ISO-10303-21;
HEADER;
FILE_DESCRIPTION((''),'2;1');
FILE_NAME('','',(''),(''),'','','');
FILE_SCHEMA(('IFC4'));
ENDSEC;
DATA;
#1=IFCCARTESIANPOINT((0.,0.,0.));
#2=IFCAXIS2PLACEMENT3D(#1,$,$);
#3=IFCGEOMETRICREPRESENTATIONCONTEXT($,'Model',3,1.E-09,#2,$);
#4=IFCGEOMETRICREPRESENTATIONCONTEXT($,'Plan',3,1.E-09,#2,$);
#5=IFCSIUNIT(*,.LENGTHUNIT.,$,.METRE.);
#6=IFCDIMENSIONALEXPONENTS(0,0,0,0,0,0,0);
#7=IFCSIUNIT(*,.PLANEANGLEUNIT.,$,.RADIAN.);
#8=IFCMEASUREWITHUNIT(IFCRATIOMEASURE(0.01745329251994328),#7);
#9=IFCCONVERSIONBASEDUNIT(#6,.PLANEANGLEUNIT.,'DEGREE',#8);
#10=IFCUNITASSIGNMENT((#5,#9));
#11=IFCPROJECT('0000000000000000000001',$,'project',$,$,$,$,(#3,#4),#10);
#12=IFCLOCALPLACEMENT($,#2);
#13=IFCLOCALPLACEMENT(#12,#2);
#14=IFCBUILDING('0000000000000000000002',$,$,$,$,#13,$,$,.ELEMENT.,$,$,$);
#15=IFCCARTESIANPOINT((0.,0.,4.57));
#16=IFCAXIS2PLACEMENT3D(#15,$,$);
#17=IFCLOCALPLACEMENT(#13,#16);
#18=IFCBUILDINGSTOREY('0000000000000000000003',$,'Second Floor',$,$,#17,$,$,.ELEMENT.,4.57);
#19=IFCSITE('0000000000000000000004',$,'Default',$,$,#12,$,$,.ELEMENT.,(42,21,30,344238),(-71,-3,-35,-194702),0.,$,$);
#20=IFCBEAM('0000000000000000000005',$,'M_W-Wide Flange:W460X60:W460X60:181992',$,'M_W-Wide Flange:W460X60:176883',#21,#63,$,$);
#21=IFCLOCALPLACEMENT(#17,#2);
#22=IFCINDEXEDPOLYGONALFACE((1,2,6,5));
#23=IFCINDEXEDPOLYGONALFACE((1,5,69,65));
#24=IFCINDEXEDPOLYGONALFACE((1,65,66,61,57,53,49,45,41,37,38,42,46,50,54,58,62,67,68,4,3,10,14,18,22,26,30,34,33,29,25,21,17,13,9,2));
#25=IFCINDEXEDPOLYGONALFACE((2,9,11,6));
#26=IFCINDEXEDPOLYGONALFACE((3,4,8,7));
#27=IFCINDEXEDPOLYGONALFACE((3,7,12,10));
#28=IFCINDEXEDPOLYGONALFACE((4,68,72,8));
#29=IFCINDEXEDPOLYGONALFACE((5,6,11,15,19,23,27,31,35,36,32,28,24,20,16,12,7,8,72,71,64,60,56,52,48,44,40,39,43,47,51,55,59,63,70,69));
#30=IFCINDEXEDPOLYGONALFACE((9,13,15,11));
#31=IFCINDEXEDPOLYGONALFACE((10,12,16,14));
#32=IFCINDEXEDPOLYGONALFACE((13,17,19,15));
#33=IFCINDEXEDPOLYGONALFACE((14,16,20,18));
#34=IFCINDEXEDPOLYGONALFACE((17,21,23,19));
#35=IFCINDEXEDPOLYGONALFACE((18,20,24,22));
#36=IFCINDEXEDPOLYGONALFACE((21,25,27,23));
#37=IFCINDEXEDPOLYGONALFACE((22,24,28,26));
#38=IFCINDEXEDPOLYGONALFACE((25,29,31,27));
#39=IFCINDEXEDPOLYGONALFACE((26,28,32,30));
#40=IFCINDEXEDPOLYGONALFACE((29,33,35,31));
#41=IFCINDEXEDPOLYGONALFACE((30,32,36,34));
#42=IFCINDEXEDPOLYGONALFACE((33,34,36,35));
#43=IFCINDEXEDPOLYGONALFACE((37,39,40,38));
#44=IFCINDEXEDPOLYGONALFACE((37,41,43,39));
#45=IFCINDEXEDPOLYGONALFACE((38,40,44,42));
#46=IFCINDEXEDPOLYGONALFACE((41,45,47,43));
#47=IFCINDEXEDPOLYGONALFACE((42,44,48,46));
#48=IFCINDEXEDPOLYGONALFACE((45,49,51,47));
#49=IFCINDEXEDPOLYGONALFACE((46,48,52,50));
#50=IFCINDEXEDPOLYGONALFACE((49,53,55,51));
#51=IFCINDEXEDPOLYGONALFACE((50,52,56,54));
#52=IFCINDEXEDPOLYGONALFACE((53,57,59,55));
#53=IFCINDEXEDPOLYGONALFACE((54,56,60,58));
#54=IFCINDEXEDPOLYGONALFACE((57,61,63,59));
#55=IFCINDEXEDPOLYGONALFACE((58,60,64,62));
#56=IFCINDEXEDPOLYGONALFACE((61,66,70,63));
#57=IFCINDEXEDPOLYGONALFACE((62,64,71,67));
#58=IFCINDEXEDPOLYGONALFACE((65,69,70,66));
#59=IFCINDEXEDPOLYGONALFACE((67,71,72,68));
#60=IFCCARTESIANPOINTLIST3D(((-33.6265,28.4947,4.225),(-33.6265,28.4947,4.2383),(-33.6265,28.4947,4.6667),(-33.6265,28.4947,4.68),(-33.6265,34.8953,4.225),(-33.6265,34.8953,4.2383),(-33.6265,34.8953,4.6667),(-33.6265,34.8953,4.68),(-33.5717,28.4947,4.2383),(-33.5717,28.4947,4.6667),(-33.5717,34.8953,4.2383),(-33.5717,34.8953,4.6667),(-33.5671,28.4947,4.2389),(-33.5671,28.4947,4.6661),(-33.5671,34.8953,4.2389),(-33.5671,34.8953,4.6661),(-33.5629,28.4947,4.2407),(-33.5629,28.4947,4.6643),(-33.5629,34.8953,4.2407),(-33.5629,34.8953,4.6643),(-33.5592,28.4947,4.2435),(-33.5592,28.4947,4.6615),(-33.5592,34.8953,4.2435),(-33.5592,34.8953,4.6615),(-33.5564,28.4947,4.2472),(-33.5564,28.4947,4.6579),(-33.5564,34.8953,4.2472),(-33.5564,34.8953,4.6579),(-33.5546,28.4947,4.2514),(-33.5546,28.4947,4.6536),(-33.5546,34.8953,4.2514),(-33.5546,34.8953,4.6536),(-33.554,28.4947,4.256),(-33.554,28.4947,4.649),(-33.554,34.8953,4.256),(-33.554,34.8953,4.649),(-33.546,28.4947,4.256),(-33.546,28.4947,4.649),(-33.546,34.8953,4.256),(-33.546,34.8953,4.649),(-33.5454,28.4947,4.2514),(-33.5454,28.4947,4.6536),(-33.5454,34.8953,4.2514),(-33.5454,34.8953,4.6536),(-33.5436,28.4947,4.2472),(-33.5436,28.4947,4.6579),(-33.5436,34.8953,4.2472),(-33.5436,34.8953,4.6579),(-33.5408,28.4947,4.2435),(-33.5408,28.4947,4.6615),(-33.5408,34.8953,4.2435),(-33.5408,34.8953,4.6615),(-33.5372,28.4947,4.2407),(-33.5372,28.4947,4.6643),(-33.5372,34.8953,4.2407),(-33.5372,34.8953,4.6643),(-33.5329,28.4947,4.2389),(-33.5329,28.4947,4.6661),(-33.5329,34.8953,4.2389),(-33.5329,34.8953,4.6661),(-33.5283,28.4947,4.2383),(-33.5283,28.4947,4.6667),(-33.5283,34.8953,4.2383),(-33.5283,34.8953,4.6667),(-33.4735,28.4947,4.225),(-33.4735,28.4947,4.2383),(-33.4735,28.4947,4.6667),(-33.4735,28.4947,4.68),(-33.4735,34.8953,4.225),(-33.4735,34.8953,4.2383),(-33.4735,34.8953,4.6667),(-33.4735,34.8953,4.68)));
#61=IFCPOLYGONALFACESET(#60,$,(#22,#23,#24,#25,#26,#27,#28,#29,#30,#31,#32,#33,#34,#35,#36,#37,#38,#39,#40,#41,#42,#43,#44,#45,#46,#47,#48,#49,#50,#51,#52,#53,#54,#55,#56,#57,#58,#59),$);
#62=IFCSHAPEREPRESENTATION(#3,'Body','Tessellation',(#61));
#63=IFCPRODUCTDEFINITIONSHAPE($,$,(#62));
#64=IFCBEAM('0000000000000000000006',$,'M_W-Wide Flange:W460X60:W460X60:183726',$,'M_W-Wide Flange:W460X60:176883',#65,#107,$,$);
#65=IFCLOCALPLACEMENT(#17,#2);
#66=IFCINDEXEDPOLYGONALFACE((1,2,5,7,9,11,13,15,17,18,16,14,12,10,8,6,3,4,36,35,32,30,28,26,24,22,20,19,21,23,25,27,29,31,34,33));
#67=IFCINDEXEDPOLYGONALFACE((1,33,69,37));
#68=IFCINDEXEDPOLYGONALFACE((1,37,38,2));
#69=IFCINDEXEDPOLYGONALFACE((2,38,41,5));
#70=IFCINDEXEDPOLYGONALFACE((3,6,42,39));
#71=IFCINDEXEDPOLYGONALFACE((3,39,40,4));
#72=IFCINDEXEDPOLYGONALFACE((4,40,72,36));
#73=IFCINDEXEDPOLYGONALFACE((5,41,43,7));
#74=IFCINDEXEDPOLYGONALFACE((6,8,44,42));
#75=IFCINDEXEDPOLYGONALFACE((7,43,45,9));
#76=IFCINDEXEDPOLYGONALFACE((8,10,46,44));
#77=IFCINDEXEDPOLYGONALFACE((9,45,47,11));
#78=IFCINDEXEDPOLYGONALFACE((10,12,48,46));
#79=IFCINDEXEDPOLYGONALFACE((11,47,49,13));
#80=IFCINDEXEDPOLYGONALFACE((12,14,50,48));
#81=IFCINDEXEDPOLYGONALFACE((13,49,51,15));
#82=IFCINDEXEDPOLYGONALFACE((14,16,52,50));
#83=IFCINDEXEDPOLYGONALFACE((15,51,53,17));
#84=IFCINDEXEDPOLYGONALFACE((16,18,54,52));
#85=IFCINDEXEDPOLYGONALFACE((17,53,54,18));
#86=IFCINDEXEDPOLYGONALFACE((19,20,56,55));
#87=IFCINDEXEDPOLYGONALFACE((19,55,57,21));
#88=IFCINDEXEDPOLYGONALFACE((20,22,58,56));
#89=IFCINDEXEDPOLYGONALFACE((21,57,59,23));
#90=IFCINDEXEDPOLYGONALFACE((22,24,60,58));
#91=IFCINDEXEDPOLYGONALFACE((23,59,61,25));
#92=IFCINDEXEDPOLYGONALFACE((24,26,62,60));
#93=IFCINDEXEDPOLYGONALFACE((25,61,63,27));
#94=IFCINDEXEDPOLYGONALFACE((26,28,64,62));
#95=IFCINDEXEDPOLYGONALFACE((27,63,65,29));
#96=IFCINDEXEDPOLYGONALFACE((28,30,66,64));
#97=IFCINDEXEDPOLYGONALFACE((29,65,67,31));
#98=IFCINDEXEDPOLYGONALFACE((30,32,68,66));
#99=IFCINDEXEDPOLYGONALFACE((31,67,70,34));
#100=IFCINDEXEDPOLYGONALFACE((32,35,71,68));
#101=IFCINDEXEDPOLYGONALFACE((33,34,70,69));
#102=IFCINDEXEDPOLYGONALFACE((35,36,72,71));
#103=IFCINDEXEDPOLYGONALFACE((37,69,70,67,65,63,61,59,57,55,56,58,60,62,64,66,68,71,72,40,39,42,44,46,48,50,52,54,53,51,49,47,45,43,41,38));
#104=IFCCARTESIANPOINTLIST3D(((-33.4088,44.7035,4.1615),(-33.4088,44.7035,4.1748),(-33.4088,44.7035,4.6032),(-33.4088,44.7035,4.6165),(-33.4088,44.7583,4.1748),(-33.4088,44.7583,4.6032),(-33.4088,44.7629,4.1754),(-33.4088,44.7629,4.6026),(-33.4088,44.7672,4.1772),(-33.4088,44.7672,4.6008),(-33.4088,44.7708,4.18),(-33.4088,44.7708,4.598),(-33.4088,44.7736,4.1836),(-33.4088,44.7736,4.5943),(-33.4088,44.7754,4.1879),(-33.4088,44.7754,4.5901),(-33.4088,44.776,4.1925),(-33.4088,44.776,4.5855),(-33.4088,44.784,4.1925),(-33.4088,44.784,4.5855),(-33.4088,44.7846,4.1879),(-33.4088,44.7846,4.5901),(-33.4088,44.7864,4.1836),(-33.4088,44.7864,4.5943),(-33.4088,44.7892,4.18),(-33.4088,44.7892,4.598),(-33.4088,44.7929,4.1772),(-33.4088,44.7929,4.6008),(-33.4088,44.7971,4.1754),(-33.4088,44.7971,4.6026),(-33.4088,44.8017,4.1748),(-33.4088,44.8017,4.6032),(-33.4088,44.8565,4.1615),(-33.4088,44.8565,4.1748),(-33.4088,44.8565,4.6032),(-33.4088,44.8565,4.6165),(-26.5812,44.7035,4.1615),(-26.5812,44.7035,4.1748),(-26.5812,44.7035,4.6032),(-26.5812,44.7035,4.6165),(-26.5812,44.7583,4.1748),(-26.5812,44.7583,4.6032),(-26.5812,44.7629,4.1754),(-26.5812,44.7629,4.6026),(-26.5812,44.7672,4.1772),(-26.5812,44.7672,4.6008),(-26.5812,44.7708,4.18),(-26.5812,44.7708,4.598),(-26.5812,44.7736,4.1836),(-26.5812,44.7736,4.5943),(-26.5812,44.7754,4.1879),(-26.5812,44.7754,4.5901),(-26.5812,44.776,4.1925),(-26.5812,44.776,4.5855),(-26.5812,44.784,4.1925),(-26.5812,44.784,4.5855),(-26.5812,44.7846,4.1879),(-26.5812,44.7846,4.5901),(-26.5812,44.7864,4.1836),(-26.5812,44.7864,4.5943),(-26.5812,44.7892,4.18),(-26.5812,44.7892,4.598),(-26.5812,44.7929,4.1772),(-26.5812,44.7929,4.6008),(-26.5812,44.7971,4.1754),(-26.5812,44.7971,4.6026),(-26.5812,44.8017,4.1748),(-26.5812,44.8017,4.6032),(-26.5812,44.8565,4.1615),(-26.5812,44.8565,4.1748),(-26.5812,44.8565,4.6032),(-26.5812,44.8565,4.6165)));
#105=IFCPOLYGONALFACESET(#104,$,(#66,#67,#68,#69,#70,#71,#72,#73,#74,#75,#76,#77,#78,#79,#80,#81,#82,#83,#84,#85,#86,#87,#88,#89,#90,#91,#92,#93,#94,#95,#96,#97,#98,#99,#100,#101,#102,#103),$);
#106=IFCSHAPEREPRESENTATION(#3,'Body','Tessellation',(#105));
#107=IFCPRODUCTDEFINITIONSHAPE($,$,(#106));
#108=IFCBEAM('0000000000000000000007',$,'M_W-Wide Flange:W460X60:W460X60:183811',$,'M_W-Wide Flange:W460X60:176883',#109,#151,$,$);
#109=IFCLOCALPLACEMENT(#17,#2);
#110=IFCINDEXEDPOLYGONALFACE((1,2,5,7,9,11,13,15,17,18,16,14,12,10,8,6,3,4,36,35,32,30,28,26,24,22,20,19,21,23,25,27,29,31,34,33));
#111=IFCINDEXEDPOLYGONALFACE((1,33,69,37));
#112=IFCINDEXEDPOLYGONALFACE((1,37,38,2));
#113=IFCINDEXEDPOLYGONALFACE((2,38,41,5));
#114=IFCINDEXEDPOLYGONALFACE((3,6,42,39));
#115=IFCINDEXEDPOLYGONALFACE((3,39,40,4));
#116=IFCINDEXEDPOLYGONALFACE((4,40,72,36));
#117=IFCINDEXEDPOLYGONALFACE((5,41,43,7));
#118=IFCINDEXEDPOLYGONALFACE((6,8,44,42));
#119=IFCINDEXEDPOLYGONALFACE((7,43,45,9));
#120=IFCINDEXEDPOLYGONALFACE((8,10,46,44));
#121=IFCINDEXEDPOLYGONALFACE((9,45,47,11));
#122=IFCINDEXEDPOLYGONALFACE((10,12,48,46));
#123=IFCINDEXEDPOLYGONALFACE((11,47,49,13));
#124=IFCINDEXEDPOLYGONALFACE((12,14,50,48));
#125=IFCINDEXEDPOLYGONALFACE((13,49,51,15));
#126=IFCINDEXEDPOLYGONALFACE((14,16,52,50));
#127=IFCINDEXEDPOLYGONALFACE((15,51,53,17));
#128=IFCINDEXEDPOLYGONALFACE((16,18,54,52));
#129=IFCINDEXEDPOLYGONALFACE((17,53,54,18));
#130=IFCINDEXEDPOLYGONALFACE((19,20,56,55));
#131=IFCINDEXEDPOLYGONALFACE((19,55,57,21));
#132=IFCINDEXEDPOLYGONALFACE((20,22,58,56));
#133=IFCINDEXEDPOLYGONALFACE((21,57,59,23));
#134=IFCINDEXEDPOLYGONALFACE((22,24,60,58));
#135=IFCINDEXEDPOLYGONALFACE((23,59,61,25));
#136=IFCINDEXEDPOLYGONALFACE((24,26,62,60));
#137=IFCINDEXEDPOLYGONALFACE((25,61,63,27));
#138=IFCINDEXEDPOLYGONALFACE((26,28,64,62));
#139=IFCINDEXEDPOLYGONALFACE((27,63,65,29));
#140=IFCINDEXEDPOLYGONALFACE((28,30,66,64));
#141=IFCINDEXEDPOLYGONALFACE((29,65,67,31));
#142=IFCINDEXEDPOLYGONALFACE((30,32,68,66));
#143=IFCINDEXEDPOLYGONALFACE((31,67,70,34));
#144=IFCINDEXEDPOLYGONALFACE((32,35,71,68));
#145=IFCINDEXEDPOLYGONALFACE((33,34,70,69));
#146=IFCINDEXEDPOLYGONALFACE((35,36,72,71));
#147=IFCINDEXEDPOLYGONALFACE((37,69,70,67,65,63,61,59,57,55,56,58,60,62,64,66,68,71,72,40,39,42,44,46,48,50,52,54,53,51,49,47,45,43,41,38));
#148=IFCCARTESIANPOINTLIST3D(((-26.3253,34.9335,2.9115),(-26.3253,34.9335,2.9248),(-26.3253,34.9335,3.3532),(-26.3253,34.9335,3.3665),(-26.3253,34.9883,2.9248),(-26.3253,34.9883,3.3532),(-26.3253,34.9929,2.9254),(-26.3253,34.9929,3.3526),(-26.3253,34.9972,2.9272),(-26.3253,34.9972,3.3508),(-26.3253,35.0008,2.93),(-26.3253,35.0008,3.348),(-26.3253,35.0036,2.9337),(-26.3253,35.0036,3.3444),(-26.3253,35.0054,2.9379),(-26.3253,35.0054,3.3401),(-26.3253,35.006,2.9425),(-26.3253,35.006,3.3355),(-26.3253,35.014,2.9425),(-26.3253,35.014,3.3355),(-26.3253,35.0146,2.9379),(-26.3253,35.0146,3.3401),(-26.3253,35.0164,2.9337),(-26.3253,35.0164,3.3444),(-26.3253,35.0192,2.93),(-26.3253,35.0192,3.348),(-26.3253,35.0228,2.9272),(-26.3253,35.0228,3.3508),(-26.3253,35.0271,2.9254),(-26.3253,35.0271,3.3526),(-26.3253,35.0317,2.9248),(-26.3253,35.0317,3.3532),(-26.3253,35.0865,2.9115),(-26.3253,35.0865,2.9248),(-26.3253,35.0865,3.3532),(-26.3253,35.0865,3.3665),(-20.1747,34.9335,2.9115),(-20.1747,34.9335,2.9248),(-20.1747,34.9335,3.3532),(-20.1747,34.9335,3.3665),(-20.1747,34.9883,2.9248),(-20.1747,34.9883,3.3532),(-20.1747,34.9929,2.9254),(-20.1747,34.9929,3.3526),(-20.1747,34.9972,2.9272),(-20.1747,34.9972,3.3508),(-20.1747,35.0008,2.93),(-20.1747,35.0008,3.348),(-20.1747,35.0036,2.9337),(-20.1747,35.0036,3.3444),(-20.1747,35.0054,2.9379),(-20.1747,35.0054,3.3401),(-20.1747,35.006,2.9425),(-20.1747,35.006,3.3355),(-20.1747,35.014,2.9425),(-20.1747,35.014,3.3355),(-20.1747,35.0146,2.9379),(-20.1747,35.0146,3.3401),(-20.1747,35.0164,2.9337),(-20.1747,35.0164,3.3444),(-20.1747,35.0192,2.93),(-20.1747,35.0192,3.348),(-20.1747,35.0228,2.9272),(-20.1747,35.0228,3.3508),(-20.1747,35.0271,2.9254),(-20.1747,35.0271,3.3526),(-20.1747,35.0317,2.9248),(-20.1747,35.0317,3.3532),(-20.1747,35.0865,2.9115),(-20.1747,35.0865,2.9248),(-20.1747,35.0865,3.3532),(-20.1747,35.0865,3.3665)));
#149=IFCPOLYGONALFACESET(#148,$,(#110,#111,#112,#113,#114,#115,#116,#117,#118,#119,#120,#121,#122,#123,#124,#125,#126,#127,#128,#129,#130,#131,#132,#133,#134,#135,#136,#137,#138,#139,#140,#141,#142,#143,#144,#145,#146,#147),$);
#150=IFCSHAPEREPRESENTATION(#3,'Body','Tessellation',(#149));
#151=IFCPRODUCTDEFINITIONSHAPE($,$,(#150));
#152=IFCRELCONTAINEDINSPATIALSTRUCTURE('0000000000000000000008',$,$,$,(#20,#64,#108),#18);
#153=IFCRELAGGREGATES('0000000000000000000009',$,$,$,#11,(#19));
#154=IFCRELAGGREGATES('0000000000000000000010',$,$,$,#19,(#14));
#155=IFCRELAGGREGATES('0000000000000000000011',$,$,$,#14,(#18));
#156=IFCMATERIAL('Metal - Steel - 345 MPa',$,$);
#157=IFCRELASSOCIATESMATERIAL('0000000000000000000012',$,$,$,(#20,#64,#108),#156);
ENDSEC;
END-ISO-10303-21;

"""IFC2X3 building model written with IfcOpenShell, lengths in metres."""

from ifc_helpers import new_model, entity, si_unit, converted_unit, frame, frame_2d, origin, place, context, project, spatial, polyline, circle_curve, parameter, trimmed, segment, composite_curve, outline, extrude, material, element, save


model = new_model("IFC2X3")

# Units and contexts
model_context = context("Model", 3, precision=1e-09, world=origin())
plan_context = context("Plan", 3, precision=1e-09, world=origin())
ifc_project = project(units=[si_unit("LENGTHUNIT", "METRE"), converted_unit("PLANEANGLEUNIT", "DEGREE", entity("IfcRatioMeasure", 0.01745329251994328), si_unit("PLANEANGLEUNIT", "RADIAN"), dimensions=[0, 0, 0, 0, 0, 0, 0])], contexts=[model_context, plan_context])

# Site, building, storey
site_placement = place(None, origin())
site = spatial("IfcSite", under=ifc_project, at=site_placement, Name="Default", CompositionType="ELEMENT", RefLatitude=(42, 21, 30, 344238), RefLongitude=(-71, -3, -35, -194702), RefElevation=0.0)
building_placement = place(site_placement, origin())
building = spatial("IfcBuilding", under=site, at=building_placement, CompositionType="ELEMENT")
storey_placement = place(building_placement, frame((0.0, 0.0, 4.57)))
storey = spatial("IfcBuildingStorey", under=building, at=storey_placement, Name="Second Floor", CompositionType="ELEMENT", Elevation=4.57)

# Shared definitions
ifc_material = material(Name="Metal - Steel - 345 MPa")

# Beams
beam_1_placement = place(storey_placement, frame((-33.55, 35.0072, 4.68), z_axis=(0.0, 0.0, 1.0), x_axis=(-1.0, 0.0, 0.0)))
element("IfcBeam", 1, at=beam_1_placement, inside=storey, material=ifc_material, Name="M_W-Wide Flange:W460X60:W460X60:181992", ObjectType="M_W-Wide Flange:W460X60:176883", context=model_context, shape_type="SweptSolid", body=[
    extrude(outline(composite_curve([segment(polyline([(0.2142, -0.0765), (0.2275, -0.0765)]), True, "CONTINUOUS"), segment(polyline([(0.2275, -0.0765), (0.2275, 0.0765)]), True, "CONTINUOUS"), segment(polyline([(0.2275, 0.0765), (0.2142, 0.0765)]), True, "CONTINUOUS"), segment(polyline([(0.2142, 0.0765), (0.2142, 0.0217)]), True, "CONTINUOUS"), segment(trimmed(circle_curve(frame_2d((0.1965, 0.0217), x_axis=(1.0, 0.0)), 0.0177), [parameter(270.0)], [parameter(360.0)], True, "PARAMETER"), False, "CONTINUOUS"), segment(polyline([(0.1965, 0.004), (-0.1965, 0.004)]), True, "CONTINUOUS"), segment(trimmed(circle_curve(frame_2d((-0.1965, 0.0217), x_axis=(0.0, -1.0)), 0.0177), [parameter(270.0)], [parameter(360.0)], True, "PARAMETER"), False, "CONTINUOUS"), segment(polyline([(-0.2142, 0.0217), (-0.2142, 0.0765)]), True, "CONTINUOUS"), segment(polyline([(-0.2142, 0.0765), (-0.2275, 0.0765)]), True, "CONTINUOUS"), segment(polyline([(-0.2275, 0.0765), (-0.2275, -0.0765)]), True, "CONTINUOUS"), segment(polyline([(-0.2275, -0.0765), (-0.2142, -0.0765)]), True, "CONTINUOUS"), segment(polyline([(-0.2142, -0.0765), (-0.2142, -0.0217)]), True, "CONTINUOUS"), segment(trimmed(circle_curve(frame_2d((-0.1965, -0.0217), x_axis=(-1.0, 0.0)), 0.0177), [parameter(270.0)], [parameter(360.0)], True, "PARAMETER"), False, "CONTINUOUS"), segment(polyline([(-0.1965, -0.004), (0.1965, -0.004)]), True, "CONTINUOUS"), segment(trimmed(circle_curve(frame_2d((0.1965, -0.0217), x_axis=(0.0, 1.0)), 0.0177), [parameter(270.0)], [parameter(0.0)], True, "PARAMETER"), False, "CONTINUOUS"), segment(polyline([(0.2142, -0.0217), (0.2142, -0.0765)]), True, "CONTINUOUS")], self_intersect=False)), frame((0.0, 6.5125, -0.2275), z_axis=(0.0, -1.0, 0.0), x_axis=(0.0, 0.0, -1.0)), (0.0, 0.0, 1.0), 6.4006),
])
beam_2_placement = place(storey_placement, frame((-33.5473, 44.78, 4.6165), z_axis=(0.0, 0.0, 1.0), x_axis=(0.0, -1.0, 0.0)))
element("IfcBeam", 2, at=beam_2_placement, inside=storey, material=ifc_material, Name="M_W-Wide Flange:W460X60:W460X60:183726", ObjectType="M_W-Wide Flange:W460X60:176883", context=model_context, shape_type="SweptSolid", body=[
    extrude(outline(composite_curve([segment(polyline([(-0.0765, -0.2142), (-0.0765, -0.2275)]), True, "CONTINUOUS"), segment(polyline([(-0.0765, -0.2275), (0.0765, -0.2275)]), True, "CONTINUOUS"), segment(polyline([(0.0765, -0.2275), (0.0765, -0.2142)]), True, "CONTINUOUS"), segment(polyline([(0.0765, -0.2142), (0.0217, -0.2142)]), True, "CONTINUOUS"), segment(trimmed(circle_curve(frame_2d((0.0217, -0.1965), x_axis=(0.0, -1.0)), 0.0177), [parameter(270.0)], [parameter(360.0)], True, "PARAMETER"), False, "CONTINUOUS"), segment(polyline([(0.004, -0.1965), (0.004, 0.1965)]), True, "CONTINUOUS"), segment(trimmed(circle_curve(frame_2d((0.0217, 0.1965), x_axis=(-1.0, 0.0)), 0.0177), [parameter(270.0)], [parameter(360.0)], True, "PARAMETER"), False, "CONTINUOUS"), segment(polyline([(0.0217, 0.2142), (0.0765, 0.2142)]), True, "CONTINUOUS"), segment(polyline([(0.0765, 0.2142), (0.0765, 0.2275)]), True, "CONTINUOUS"), segment(polyline([(0.0765, 0.2275), (-0.0765, 0.2275)]), True, "CONTINUOUS"), segment(polyline([(-0.0765, 0.2275), (-0.0765, 0.2142)]), True, "CONTINUOUS"), segment(polyline([(-0.0765, 0.2142), (-0.0217, 0.2142)]), True, "CONTINUOUS"), segment(trimmed(circle_curve(frame_2d((-0.0217, 0.1965), x_axis=(0.0, 1.0)), 0.0177), [parameter(270.0)], [parameter(360.0)], True, "PARAMETER"), False, "CONTINUOUS"), segment(polyline([(-0.004, 0.1965), (-0.004, -0.1965)]), True, "CONTINUOUS"), segment(trimmed(circle_curve(frame_2d((-0.0217, -0.1965), x_axis=(1.0, 0.0)), 0.0177), [parameter(270.0)], [parameter(0.0)], True, "PARAMETER"), False, "CONTINUOUS"), segment(polyline([(-0.0217, -0.2142), (-0.0765, -0.2142)]), True, "CONTINUOUS")], self_intersect=False)), frame((0.0, 0.1385, -0.2275), z_axis=(0.0, -1.0, 0.0), x_axis=(1.0, 0.0, 0.0)), (0.0, 0.0, -1.0), 6.8276),
])
beam_3_placement = place(storey_placement, frame((-20.1843, 35.01, 3.3665), z_axis=(0.0, 0.0, 1.0), x_axis=(0.0, 1.0, 0.0)))
element("IfcBeam", 3, at=beam_3_placement, inside=storey, material=ifc_material, Name="M_W-Wide Flange:W460X60:W460X60:183811", ObjectType="M_W-Wide Flange:W460X60:176883", context=model_context, shape_type="SweptSolid", body=[
    extrude(outline(composite_curve([segment(polyline([(0.2142, -0.0765), (0.2275, -0.0765)]), True, "CONTINUOUS"), segment(polyline([(0.2275, -0.0765), (0.2275, 0.0765)]), True, "CONTINUOUS"), segment(polyline([(0.2275, 0.0765), (0.2142, 0.0765)]), True, "CONTINUOUS"), segment(polyline([(0.2142, 0.0765), (0.2142, 0.0217)]), True, "CONTINUOUS"), segment(trimmed(circle_curve(frame_2d((0.1965, 0.0217), x_axis=(1.0, 0.0)), 0.0177), [parameter(270.0)], [parameter(360.0)], True, "PARAMETER"), False, "CONTINUOUS"), segment(polyline([(0.1965, 0.004), (-0.1965, 0.004)]), True, "CONTINUOUS"), segment(trimmed(circle_curve(frame_2d((-0.1965, 0.0217), x_axis=(0.0, -1.0)), 0.0177), [parameter(270.0)], [parameter(360.0)], True, "PARAMETER"), False, "CONTINUOUS"), segment(polyline([(-0.2142, 0.0217), (-0.2142, 0.0765)]), True, "CONTINUOUS"), segment(polyline([(-0.2142, 0.0765), (-0.2275, 0.0765)]), True, "CONTINUOUS"), segment(polyline([(-0.2275, 0.0765), (-0.2275, -0.0765)]), True, "CONTINUOUS"), segment(polyline([(-0.2275, -0.0765), (-0.2142, -0.0765)]), True, "CONTINUOUS"), segment(polyline([(-0.2142, -0.0765), (-0.2142, -0.0217)]), True, "CONTINUOUS"), segment(trimmed(circle_curve(frame_2d((-0.1965, -0.0217), x_axis=(-1.0, 0.0)), 0.0177), [parameter(270.0)], [parameter(360.0)], True, "PARAMETER"), False, "CONTINUOUS"), segment(polyline([(-0.1965, -0.004), (0.1965, -0.004)]), True, "CONTINUOUS"), segment(trimmed(circle_curve(frame_2d((0.1965, -0.0217), x_axis=(0.0, 1.0)), 0.0177), [parameter(270.0)], [parameter(0.0)], True, "PARAMETER"), False, "CONTINUOUS"), segment(polyline([(0.2142, -0.0217), (0.2142, -0.0765)]), True, "CONTINUOUS")], self_intersect=False)), frame((0.0, 6.141, -0.2275), z_axis=(0.0, -1.0, 0.0), x_axis=(0.0, 0.0, -1.0)), (0.0, 0.0, 1.0), 6.1506),
])

save(model, "model.ifc")
